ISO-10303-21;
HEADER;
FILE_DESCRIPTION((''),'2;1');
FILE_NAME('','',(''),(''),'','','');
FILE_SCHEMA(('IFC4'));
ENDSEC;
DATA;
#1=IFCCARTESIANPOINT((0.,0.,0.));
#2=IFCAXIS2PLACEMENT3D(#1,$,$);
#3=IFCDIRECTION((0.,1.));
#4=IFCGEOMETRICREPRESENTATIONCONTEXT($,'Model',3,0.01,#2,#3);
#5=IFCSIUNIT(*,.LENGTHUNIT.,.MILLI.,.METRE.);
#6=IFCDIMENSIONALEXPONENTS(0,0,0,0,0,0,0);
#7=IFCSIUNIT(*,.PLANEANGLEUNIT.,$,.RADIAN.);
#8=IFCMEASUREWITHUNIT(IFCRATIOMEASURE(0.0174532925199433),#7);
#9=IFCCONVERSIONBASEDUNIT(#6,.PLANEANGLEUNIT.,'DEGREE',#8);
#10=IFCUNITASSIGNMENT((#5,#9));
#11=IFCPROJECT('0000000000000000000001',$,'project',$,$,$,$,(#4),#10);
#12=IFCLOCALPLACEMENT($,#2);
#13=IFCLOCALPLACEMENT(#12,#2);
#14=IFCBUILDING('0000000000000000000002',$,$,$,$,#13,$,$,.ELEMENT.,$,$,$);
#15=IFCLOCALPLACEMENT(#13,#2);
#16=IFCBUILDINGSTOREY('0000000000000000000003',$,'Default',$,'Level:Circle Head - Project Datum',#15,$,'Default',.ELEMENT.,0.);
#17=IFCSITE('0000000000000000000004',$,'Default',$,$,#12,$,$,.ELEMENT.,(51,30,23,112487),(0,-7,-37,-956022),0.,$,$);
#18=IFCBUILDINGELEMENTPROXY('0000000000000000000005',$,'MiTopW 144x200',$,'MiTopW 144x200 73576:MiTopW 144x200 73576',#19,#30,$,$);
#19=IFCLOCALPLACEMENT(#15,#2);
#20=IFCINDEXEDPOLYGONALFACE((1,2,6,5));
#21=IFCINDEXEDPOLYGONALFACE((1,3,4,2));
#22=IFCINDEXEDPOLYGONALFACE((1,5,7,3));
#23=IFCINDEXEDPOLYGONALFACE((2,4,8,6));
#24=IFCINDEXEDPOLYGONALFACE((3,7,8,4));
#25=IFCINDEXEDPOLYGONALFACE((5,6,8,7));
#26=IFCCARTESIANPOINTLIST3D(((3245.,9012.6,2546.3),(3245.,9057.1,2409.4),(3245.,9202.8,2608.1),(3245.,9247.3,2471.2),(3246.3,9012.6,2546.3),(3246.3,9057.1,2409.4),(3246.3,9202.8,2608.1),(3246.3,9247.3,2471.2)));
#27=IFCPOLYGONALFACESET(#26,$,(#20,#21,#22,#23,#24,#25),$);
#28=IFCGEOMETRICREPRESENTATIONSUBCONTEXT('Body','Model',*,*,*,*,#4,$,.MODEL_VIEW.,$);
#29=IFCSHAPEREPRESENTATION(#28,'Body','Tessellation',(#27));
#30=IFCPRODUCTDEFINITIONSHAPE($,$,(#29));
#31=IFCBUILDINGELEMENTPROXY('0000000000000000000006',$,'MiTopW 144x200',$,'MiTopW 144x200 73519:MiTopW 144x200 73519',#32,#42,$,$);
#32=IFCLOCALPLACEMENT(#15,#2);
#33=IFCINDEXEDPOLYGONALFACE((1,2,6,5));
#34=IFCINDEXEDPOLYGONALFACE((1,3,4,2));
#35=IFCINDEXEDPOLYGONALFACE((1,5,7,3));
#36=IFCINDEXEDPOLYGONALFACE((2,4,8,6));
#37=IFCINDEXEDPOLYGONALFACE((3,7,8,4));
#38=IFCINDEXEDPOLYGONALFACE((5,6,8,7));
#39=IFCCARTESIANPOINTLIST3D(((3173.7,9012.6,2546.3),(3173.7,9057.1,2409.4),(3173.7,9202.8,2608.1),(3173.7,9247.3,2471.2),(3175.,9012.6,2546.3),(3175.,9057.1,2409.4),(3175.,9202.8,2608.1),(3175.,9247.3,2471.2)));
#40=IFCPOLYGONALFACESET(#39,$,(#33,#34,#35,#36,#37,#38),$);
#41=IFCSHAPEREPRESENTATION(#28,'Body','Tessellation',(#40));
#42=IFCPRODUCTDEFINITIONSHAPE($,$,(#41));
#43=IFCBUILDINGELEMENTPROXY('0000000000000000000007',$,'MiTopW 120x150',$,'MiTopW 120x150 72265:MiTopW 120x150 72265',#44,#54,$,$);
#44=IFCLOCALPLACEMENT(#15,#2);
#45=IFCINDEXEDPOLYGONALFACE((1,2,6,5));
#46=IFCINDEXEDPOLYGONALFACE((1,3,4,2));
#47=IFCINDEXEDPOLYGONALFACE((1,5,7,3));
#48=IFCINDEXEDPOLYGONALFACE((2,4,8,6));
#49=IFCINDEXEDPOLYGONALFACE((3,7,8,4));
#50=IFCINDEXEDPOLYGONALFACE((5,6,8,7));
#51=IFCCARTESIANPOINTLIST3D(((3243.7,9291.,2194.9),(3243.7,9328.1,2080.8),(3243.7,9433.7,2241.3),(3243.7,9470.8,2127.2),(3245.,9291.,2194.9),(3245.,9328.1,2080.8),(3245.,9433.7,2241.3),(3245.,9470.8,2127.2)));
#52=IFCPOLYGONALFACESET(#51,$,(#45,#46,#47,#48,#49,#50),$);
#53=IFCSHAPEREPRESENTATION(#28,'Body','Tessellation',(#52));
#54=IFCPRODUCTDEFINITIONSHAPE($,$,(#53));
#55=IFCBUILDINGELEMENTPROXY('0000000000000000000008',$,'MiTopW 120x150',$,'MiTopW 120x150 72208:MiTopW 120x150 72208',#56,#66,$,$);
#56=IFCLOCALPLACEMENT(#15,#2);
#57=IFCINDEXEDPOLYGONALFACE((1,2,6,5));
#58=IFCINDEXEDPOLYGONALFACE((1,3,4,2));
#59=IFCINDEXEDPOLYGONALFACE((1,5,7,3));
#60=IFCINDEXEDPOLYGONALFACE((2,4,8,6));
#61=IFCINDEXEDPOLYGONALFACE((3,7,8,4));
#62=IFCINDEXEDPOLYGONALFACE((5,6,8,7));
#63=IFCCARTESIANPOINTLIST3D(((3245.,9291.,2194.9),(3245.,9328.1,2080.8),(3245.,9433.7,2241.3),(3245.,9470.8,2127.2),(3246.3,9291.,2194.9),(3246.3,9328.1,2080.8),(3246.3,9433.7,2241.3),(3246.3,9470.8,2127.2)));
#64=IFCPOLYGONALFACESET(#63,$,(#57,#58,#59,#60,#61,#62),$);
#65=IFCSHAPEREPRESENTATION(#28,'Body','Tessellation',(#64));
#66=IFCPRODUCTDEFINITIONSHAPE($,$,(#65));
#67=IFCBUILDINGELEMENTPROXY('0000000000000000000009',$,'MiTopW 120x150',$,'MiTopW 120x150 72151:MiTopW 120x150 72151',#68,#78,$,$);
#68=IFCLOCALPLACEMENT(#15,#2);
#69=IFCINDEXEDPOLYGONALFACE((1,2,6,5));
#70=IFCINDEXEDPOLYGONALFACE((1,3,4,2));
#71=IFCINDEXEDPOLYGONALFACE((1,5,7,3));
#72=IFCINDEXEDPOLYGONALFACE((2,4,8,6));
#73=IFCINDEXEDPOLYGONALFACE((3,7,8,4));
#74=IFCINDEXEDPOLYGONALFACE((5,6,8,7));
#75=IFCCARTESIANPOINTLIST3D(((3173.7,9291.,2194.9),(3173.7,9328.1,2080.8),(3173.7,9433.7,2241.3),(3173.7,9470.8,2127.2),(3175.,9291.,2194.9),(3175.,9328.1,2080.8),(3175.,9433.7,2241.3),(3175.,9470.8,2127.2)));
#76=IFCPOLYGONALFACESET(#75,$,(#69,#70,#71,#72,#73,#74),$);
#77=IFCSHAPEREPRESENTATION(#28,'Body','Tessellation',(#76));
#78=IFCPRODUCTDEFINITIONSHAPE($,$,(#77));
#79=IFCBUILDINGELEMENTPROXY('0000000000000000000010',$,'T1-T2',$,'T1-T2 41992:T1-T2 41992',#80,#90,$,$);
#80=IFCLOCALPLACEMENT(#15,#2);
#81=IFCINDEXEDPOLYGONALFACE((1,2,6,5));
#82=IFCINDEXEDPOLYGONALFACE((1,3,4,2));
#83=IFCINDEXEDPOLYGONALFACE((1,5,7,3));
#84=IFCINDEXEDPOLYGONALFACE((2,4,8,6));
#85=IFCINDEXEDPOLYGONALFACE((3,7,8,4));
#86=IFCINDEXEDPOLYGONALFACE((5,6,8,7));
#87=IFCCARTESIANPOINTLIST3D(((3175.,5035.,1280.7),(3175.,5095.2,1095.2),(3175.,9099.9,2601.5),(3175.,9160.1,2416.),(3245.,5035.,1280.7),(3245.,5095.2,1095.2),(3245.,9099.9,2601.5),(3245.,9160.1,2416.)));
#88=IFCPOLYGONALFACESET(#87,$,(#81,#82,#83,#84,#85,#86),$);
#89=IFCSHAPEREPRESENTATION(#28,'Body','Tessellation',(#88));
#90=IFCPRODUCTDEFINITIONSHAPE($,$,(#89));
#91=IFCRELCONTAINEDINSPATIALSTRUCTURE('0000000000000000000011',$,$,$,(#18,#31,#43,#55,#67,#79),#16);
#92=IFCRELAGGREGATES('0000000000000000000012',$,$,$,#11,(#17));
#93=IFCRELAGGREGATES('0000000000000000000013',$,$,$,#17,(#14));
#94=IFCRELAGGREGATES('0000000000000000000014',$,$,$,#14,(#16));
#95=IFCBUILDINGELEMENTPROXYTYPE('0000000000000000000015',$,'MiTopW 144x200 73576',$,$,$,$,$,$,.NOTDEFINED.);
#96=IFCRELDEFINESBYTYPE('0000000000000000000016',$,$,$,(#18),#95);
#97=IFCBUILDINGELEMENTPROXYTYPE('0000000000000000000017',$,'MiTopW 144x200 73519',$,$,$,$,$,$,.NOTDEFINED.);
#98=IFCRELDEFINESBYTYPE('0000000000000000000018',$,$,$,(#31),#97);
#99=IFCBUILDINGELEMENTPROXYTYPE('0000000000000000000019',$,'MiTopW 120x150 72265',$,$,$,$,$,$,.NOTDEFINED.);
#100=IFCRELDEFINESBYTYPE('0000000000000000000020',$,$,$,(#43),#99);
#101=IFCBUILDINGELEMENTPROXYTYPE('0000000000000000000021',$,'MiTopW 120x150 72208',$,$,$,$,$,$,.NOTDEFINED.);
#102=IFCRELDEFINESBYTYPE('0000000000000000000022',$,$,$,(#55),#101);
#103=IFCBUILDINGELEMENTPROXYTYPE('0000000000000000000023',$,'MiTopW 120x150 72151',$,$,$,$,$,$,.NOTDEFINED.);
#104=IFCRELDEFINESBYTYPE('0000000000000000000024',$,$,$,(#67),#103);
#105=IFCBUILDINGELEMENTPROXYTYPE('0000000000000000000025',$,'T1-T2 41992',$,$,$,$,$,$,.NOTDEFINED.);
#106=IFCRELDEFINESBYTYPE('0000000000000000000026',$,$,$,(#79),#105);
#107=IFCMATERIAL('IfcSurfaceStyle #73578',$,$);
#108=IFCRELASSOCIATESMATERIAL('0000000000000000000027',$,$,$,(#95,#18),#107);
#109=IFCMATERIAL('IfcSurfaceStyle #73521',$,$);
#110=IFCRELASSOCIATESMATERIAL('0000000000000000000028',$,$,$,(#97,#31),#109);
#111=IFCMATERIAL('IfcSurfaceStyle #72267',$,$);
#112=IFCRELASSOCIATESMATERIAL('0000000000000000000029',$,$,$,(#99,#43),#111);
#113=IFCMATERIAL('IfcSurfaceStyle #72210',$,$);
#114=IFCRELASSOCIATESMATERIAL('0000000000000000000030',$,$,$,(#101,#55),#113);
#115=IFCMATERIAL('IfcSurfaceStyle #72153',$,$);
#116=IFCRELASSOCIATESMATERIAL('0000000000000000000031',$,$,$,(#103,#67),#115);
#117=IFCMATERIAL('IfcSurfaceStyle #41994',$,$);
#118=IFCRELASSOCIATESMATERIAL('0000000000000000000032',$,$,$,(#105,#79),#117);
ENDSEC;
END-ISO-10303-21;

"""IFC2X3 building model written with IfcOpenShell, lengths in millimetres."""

from ifc_helpers import new_model, entity, si_unit, converted_unit, direction, frame, origin, place, context, subcontext, project, spatial, polyline, outline, extrude, source, transform, mapped, material, type_object, type_shapes, element, save


model = new_model("IFC2X3")

# Units and contexts
model_context = context("Model", 3, precision=0.01, world=origin(), true_north=direction((0.0, 1.0)))
body_context = subcontext(model_context, "Body", "Model", "MODEL_VIEW")
ifc_project = project(units=[si_unit("LENGTHUNIT", "METRE", prefix="MILLI"), converted_unit("PLANEANGLEUNIT", "DEGREE", entity("IfcRatioMeasure", 0.0174532925199433), si_unit("PLANEANGLEUNIT", "RADIAN"), dimensions=[0, 0, 0, 0, 0, 0, 0])], contexts=[model_context])

# Site, building, storey
site_placement = place(None, origin())
site = spatial("IfcSite", under=ifc_project, at=site_placement, Name="Default", CompositionType="ELEMENT", RefLatitude=(51, 30, 23, 112487), RefLongitude=(0, -7, -37, -956022), RefElevation=0.0)
building_placement = place(site_placement, origin())
building = spatial("IfcBuilding", under=site, at=building_placement, CompositionType="ELEMENT")
storey_placement = place(building_placement, origin())
storey = spatial("IfcBuildingStorey", under=building, at=storey_placement, Name="Default", ObjectType="Level:Circle Head - Project Datum", LongName="Default", CompositionType="ELEMENT", Elevation=0.0)

# Building element proxies
ifc_material_1 = material(Name="IfcSurfaceStyle #73578")
building_element_proxy_type_1 = type_object("IfcBuildingElementProxyType", Name="MiTopW 144x200 73576", PredefinedType="NOTDEFINED", material=ifc_material_1)
shared_shape_1 = source(origin(), body_context, "Body", "SweptSolid", [
    extrude(outline(polyline([(-100.0, -72.0), (100.0, -72.0), (100.0, 72.0), (-100.0, 72.0), (-100.0, -72.0)])), frame((100.0, 72.0, 0.0), z_axis=(0.0, 0.0, 1.0), x_axis=(-1.0, 0.0, 0.0)), (0.0, 0.0, 1.0), 1.3),
])
type_shapes(building_element_proxy_type_1, [shared_shape_1])
proxy_1_placement = place(building_placement, frame((3246.3, 9012.6, 2546.3), z_axis=(-1.0, 0.0, 0.0), x_axis=(0.0, 0.951057, 0.309017)))
element("IfcBuildingElementProxy", 1, at=proxy_1_placement, inside=storey, type_object=building_element_proxy_type_1, material=ifc_material_1, Name="MiTopW 144x200", ObjectType="MiTopW 144x200 73576:MiTopW 144x200 73576", context=body_context, shape_type="MappedRepresentation", body=[
    mapped(shared_shape_1, transform((0.0, 0.0, 0.0), scale=1.0)),
])
ifc_material_2 = material(Name="IfcSurfaceStyle #73521")
building_element_proxy_type_2 = type_object("IfcBuildingElementProxyType", Name="MiTopW 144x200 73519", PredefinedType="NOTDEFINED", material=ifc_material_2)
shared_shape_2 = source(origin(), body_context, "Body", "SweptSolid", [
    extrude(outline(polyline([(-100.0, -72.0), (100.0, -72.0), (100.0, 72.0), (-100.0, 72.0), (-100.0, -72.0)])), frame((100.0, 72.0, 0.0), z_axis=(0.0, 0.0, 1.0), x_axis=(-1.0, 0.0, 0.0)), (0.0, 0.0, 1.0), 1.3),
])
type_shapes(building_element_proxy_type_2, [shared_shape_2])
proxy_2_placement = place(building_placement, frame((3175.0, 9012.6, 2546.3), z_axis=(-1.0, 0.0, 0.0), x_axis=(0.0, 0.951057, 0.309017)))
element("IfcBuildingElementProxy", 2, at=proxy_2_placement, inside=storey, type_object=building_element_proxy_type_2, material=ifc_material_2, Name="MiTopW 144x200", ObjectType="MiTopW 144x200 73519:MiTopW 144x200 73519", context=body_context, shape_type="MappedRepresentation", body=[
    mapped(shared_shape_2, transform((0.0, 0.0, 0.0), scale=1.0)),
])
ifc_material_3 = material(Name="IfcSurfaceStyle #72267")
building_element_proxy_type_3 = type_object("IfcBuildingElementProxyType", Name="MiTopW 120x150 72265", PredefinedType="NOTDEFINED", material=ifc_material_3)
shared_shape_3 = source(origin(), body_context, "Body", "SweptSolid", [
    extrude(outline(polyline([(-75.0, -60.0), (75.0, -60.0), (75.0, 60.0), (-75.0, 60.0), (-75.0, -60.0)])), frame((75.0, 60.0, 0.0), z_axis=(0.0, 0.0, 1.0), x_axis=(-1.0, 0.0, 0.0)), (0.0, 0.0, 1.0), 1.3),
])
type_shapes(building_element_proxy_type_3, [shared_shape_3])
proxy_3_placement = place(building_placement, frame((3245.0, 9291.0, 2194.9), z_axis=(-1.0, 0.0, 0.0), x_axis=(0.0, 0.951057, 0.309017)))
element("IfcBuildingElementProxy", 3, at=proxy_3_placement, inside=storey, type_object=building_element_proxy_type_3, material=ifc_material_3, Name="MiTopW 120x150", ObjectType="MiTopW 120x150 72265:MiTopW 120x150 72265", context=body_context, shape_type="MappedRepresentation", body=[
    mapped(shared_shape_3, transform((0.0, 0.0, 0.0), scale=1.0)),
])
ifc_material_4 = material(Name="IfcSurfaceStyle #72210")
building_element_proxy_type_4 = type_object("IfcBuildingElementProxyType", Name="MiTopW 120x150 72208", PredefinedType="NOTDEFINED", material=ifc_material_4)
shared_shape_4 = source(origin(), body_context, "Body", "SweptSolid", [
    extrude(outline(polyline([(-75.0, -60.0), (75.0, -60.0), (75.0, 60.0), (-75.0, 60.0), (-75.0, -60.0)])), frame((75.0, 60.0, 0.0), z_axis=(0.0, 0.0, 1.0), x_axis=(-1.0, 0.0, 0.0)), (0.0, 0.0, 1.0), 1.3),
])
type_shapes(building_element_proxy_type_4, [shared_shape_4])
proxy_4_placement = place(building_placement, frame((3246.3, 9291.0, 2194.9), z_axis=(-1.0, 0.0, 0.0), x_axis=(0.0, 0.951057, 0.309017)))
element("IfcBuildingElementProxy", 4, at=proxy_4_placement, inside=storey, type_object=building_element_proxy_type_4, material=ifc_material_4, Name="MiTopW 120x150", ObjectType="MiTopW 120x150 72208:MiTopW 120x150 72208", context=body_context, shape_type="MappedRepresentation", body=[
    mapped(shared_shape_4, transform((0.0, 0.0, 0.0), scale=1.0)),
])
ifc_material_5 = material(Name="IfcSurfaceStyle #72153")
building_element_proxy_type_5 = type_object("IfcBuildingElementProxyType", Name="MiTopW 120x150 72151", PredefinedType="NOTDEFINED", material=ifc_material_5)
shared_shape_5 = source(origin(), body_context, "Body", "SweptSolid", [
    extrude(outline(polyline([(-75.0, -60.0), (75.0, -60.0), (75.0, 60.0), (-75.0, 60.0), (-75.0, -60.0)])), frame((75.0, 60.0, 0.0), z_axis=(0.0, 0.0, 1.0), x_axis=(-1.0, 0.0, 0.0)), (0.0, 0.0, 1.0), 1.3),
])
type_shapes(building_element_proxy_type_5, [shared_shape_5])
proxy_5_placement = place(building_placement, frame((3175.0, 9291.0, 2194.9), z_axis=(-1.0, 0.0, 0.0), x_axis=(0.0, 0.951057, 0.309017)))
element("IfcBuildingElementProxy", 5, at=proxy_5_placement, inside=storey, type_object=building_element_proxy_type_5, material=ifc_material_5, Name="MiTopW 120x150", ObjectType="MiTopW 120x150 72151:MiTopW 120x150 72151", context=body_context, shape_type="MappedRepresentation", body=[
    mapped(shared_shape_5, transform((0.0, 0.0, 0.0), scale=1.0)),
])
ifc_material_6 = material(Name="IfcSurfaceStyle #41994")
building_element_proxy_type_6 = type_object("IfcBuildingElementProxyType", Name="T1-T2 41992", PredefinedType="NOTDEFINED", material=ifc_material_6)
shared_shape_6 = source(origin(), body_context, "Body", "SweptSolid", [
    extrude(outline(polyline([(-2137.0, -97.5), (2137.0, -97.5), (2137.0, 97.5), (-2137.0, 97.5), (-2137.0, -97.5)])), frame((2137.0, 97.5, 0.0), z_axis=(0.0, 0.0, 1.0), x_axis=(-1.0, 0.0, 0.0)), (0.0, 0.0, 1.0), 70.0),
])
type_shapes(building_element_proxy_type_6, [shared_shape_6])
proxy_6_placement = place(building_placement, frame((3245.0, 9160.1, 2416.0), z_axis=(-1.0, 0.0, 0.0), x_axis=(0.0, -0.951057, -0.309017)))
element("IfcBuildingElementProxy", 6, at=proxy_6_placement, inside=storey, type_object=building_element_proxy_type_6, material=ifc_material_6, Name="T1-T2", ObjectType="T1-T2 41992:T1-T2 41992", context=body_context, shape_type="MappedRepresentation", body=[
    mapped(shared_shape_6, transform((0.0, 0.0, 0.0), scale=1.0)),
])

save(model, "model.ifc")
